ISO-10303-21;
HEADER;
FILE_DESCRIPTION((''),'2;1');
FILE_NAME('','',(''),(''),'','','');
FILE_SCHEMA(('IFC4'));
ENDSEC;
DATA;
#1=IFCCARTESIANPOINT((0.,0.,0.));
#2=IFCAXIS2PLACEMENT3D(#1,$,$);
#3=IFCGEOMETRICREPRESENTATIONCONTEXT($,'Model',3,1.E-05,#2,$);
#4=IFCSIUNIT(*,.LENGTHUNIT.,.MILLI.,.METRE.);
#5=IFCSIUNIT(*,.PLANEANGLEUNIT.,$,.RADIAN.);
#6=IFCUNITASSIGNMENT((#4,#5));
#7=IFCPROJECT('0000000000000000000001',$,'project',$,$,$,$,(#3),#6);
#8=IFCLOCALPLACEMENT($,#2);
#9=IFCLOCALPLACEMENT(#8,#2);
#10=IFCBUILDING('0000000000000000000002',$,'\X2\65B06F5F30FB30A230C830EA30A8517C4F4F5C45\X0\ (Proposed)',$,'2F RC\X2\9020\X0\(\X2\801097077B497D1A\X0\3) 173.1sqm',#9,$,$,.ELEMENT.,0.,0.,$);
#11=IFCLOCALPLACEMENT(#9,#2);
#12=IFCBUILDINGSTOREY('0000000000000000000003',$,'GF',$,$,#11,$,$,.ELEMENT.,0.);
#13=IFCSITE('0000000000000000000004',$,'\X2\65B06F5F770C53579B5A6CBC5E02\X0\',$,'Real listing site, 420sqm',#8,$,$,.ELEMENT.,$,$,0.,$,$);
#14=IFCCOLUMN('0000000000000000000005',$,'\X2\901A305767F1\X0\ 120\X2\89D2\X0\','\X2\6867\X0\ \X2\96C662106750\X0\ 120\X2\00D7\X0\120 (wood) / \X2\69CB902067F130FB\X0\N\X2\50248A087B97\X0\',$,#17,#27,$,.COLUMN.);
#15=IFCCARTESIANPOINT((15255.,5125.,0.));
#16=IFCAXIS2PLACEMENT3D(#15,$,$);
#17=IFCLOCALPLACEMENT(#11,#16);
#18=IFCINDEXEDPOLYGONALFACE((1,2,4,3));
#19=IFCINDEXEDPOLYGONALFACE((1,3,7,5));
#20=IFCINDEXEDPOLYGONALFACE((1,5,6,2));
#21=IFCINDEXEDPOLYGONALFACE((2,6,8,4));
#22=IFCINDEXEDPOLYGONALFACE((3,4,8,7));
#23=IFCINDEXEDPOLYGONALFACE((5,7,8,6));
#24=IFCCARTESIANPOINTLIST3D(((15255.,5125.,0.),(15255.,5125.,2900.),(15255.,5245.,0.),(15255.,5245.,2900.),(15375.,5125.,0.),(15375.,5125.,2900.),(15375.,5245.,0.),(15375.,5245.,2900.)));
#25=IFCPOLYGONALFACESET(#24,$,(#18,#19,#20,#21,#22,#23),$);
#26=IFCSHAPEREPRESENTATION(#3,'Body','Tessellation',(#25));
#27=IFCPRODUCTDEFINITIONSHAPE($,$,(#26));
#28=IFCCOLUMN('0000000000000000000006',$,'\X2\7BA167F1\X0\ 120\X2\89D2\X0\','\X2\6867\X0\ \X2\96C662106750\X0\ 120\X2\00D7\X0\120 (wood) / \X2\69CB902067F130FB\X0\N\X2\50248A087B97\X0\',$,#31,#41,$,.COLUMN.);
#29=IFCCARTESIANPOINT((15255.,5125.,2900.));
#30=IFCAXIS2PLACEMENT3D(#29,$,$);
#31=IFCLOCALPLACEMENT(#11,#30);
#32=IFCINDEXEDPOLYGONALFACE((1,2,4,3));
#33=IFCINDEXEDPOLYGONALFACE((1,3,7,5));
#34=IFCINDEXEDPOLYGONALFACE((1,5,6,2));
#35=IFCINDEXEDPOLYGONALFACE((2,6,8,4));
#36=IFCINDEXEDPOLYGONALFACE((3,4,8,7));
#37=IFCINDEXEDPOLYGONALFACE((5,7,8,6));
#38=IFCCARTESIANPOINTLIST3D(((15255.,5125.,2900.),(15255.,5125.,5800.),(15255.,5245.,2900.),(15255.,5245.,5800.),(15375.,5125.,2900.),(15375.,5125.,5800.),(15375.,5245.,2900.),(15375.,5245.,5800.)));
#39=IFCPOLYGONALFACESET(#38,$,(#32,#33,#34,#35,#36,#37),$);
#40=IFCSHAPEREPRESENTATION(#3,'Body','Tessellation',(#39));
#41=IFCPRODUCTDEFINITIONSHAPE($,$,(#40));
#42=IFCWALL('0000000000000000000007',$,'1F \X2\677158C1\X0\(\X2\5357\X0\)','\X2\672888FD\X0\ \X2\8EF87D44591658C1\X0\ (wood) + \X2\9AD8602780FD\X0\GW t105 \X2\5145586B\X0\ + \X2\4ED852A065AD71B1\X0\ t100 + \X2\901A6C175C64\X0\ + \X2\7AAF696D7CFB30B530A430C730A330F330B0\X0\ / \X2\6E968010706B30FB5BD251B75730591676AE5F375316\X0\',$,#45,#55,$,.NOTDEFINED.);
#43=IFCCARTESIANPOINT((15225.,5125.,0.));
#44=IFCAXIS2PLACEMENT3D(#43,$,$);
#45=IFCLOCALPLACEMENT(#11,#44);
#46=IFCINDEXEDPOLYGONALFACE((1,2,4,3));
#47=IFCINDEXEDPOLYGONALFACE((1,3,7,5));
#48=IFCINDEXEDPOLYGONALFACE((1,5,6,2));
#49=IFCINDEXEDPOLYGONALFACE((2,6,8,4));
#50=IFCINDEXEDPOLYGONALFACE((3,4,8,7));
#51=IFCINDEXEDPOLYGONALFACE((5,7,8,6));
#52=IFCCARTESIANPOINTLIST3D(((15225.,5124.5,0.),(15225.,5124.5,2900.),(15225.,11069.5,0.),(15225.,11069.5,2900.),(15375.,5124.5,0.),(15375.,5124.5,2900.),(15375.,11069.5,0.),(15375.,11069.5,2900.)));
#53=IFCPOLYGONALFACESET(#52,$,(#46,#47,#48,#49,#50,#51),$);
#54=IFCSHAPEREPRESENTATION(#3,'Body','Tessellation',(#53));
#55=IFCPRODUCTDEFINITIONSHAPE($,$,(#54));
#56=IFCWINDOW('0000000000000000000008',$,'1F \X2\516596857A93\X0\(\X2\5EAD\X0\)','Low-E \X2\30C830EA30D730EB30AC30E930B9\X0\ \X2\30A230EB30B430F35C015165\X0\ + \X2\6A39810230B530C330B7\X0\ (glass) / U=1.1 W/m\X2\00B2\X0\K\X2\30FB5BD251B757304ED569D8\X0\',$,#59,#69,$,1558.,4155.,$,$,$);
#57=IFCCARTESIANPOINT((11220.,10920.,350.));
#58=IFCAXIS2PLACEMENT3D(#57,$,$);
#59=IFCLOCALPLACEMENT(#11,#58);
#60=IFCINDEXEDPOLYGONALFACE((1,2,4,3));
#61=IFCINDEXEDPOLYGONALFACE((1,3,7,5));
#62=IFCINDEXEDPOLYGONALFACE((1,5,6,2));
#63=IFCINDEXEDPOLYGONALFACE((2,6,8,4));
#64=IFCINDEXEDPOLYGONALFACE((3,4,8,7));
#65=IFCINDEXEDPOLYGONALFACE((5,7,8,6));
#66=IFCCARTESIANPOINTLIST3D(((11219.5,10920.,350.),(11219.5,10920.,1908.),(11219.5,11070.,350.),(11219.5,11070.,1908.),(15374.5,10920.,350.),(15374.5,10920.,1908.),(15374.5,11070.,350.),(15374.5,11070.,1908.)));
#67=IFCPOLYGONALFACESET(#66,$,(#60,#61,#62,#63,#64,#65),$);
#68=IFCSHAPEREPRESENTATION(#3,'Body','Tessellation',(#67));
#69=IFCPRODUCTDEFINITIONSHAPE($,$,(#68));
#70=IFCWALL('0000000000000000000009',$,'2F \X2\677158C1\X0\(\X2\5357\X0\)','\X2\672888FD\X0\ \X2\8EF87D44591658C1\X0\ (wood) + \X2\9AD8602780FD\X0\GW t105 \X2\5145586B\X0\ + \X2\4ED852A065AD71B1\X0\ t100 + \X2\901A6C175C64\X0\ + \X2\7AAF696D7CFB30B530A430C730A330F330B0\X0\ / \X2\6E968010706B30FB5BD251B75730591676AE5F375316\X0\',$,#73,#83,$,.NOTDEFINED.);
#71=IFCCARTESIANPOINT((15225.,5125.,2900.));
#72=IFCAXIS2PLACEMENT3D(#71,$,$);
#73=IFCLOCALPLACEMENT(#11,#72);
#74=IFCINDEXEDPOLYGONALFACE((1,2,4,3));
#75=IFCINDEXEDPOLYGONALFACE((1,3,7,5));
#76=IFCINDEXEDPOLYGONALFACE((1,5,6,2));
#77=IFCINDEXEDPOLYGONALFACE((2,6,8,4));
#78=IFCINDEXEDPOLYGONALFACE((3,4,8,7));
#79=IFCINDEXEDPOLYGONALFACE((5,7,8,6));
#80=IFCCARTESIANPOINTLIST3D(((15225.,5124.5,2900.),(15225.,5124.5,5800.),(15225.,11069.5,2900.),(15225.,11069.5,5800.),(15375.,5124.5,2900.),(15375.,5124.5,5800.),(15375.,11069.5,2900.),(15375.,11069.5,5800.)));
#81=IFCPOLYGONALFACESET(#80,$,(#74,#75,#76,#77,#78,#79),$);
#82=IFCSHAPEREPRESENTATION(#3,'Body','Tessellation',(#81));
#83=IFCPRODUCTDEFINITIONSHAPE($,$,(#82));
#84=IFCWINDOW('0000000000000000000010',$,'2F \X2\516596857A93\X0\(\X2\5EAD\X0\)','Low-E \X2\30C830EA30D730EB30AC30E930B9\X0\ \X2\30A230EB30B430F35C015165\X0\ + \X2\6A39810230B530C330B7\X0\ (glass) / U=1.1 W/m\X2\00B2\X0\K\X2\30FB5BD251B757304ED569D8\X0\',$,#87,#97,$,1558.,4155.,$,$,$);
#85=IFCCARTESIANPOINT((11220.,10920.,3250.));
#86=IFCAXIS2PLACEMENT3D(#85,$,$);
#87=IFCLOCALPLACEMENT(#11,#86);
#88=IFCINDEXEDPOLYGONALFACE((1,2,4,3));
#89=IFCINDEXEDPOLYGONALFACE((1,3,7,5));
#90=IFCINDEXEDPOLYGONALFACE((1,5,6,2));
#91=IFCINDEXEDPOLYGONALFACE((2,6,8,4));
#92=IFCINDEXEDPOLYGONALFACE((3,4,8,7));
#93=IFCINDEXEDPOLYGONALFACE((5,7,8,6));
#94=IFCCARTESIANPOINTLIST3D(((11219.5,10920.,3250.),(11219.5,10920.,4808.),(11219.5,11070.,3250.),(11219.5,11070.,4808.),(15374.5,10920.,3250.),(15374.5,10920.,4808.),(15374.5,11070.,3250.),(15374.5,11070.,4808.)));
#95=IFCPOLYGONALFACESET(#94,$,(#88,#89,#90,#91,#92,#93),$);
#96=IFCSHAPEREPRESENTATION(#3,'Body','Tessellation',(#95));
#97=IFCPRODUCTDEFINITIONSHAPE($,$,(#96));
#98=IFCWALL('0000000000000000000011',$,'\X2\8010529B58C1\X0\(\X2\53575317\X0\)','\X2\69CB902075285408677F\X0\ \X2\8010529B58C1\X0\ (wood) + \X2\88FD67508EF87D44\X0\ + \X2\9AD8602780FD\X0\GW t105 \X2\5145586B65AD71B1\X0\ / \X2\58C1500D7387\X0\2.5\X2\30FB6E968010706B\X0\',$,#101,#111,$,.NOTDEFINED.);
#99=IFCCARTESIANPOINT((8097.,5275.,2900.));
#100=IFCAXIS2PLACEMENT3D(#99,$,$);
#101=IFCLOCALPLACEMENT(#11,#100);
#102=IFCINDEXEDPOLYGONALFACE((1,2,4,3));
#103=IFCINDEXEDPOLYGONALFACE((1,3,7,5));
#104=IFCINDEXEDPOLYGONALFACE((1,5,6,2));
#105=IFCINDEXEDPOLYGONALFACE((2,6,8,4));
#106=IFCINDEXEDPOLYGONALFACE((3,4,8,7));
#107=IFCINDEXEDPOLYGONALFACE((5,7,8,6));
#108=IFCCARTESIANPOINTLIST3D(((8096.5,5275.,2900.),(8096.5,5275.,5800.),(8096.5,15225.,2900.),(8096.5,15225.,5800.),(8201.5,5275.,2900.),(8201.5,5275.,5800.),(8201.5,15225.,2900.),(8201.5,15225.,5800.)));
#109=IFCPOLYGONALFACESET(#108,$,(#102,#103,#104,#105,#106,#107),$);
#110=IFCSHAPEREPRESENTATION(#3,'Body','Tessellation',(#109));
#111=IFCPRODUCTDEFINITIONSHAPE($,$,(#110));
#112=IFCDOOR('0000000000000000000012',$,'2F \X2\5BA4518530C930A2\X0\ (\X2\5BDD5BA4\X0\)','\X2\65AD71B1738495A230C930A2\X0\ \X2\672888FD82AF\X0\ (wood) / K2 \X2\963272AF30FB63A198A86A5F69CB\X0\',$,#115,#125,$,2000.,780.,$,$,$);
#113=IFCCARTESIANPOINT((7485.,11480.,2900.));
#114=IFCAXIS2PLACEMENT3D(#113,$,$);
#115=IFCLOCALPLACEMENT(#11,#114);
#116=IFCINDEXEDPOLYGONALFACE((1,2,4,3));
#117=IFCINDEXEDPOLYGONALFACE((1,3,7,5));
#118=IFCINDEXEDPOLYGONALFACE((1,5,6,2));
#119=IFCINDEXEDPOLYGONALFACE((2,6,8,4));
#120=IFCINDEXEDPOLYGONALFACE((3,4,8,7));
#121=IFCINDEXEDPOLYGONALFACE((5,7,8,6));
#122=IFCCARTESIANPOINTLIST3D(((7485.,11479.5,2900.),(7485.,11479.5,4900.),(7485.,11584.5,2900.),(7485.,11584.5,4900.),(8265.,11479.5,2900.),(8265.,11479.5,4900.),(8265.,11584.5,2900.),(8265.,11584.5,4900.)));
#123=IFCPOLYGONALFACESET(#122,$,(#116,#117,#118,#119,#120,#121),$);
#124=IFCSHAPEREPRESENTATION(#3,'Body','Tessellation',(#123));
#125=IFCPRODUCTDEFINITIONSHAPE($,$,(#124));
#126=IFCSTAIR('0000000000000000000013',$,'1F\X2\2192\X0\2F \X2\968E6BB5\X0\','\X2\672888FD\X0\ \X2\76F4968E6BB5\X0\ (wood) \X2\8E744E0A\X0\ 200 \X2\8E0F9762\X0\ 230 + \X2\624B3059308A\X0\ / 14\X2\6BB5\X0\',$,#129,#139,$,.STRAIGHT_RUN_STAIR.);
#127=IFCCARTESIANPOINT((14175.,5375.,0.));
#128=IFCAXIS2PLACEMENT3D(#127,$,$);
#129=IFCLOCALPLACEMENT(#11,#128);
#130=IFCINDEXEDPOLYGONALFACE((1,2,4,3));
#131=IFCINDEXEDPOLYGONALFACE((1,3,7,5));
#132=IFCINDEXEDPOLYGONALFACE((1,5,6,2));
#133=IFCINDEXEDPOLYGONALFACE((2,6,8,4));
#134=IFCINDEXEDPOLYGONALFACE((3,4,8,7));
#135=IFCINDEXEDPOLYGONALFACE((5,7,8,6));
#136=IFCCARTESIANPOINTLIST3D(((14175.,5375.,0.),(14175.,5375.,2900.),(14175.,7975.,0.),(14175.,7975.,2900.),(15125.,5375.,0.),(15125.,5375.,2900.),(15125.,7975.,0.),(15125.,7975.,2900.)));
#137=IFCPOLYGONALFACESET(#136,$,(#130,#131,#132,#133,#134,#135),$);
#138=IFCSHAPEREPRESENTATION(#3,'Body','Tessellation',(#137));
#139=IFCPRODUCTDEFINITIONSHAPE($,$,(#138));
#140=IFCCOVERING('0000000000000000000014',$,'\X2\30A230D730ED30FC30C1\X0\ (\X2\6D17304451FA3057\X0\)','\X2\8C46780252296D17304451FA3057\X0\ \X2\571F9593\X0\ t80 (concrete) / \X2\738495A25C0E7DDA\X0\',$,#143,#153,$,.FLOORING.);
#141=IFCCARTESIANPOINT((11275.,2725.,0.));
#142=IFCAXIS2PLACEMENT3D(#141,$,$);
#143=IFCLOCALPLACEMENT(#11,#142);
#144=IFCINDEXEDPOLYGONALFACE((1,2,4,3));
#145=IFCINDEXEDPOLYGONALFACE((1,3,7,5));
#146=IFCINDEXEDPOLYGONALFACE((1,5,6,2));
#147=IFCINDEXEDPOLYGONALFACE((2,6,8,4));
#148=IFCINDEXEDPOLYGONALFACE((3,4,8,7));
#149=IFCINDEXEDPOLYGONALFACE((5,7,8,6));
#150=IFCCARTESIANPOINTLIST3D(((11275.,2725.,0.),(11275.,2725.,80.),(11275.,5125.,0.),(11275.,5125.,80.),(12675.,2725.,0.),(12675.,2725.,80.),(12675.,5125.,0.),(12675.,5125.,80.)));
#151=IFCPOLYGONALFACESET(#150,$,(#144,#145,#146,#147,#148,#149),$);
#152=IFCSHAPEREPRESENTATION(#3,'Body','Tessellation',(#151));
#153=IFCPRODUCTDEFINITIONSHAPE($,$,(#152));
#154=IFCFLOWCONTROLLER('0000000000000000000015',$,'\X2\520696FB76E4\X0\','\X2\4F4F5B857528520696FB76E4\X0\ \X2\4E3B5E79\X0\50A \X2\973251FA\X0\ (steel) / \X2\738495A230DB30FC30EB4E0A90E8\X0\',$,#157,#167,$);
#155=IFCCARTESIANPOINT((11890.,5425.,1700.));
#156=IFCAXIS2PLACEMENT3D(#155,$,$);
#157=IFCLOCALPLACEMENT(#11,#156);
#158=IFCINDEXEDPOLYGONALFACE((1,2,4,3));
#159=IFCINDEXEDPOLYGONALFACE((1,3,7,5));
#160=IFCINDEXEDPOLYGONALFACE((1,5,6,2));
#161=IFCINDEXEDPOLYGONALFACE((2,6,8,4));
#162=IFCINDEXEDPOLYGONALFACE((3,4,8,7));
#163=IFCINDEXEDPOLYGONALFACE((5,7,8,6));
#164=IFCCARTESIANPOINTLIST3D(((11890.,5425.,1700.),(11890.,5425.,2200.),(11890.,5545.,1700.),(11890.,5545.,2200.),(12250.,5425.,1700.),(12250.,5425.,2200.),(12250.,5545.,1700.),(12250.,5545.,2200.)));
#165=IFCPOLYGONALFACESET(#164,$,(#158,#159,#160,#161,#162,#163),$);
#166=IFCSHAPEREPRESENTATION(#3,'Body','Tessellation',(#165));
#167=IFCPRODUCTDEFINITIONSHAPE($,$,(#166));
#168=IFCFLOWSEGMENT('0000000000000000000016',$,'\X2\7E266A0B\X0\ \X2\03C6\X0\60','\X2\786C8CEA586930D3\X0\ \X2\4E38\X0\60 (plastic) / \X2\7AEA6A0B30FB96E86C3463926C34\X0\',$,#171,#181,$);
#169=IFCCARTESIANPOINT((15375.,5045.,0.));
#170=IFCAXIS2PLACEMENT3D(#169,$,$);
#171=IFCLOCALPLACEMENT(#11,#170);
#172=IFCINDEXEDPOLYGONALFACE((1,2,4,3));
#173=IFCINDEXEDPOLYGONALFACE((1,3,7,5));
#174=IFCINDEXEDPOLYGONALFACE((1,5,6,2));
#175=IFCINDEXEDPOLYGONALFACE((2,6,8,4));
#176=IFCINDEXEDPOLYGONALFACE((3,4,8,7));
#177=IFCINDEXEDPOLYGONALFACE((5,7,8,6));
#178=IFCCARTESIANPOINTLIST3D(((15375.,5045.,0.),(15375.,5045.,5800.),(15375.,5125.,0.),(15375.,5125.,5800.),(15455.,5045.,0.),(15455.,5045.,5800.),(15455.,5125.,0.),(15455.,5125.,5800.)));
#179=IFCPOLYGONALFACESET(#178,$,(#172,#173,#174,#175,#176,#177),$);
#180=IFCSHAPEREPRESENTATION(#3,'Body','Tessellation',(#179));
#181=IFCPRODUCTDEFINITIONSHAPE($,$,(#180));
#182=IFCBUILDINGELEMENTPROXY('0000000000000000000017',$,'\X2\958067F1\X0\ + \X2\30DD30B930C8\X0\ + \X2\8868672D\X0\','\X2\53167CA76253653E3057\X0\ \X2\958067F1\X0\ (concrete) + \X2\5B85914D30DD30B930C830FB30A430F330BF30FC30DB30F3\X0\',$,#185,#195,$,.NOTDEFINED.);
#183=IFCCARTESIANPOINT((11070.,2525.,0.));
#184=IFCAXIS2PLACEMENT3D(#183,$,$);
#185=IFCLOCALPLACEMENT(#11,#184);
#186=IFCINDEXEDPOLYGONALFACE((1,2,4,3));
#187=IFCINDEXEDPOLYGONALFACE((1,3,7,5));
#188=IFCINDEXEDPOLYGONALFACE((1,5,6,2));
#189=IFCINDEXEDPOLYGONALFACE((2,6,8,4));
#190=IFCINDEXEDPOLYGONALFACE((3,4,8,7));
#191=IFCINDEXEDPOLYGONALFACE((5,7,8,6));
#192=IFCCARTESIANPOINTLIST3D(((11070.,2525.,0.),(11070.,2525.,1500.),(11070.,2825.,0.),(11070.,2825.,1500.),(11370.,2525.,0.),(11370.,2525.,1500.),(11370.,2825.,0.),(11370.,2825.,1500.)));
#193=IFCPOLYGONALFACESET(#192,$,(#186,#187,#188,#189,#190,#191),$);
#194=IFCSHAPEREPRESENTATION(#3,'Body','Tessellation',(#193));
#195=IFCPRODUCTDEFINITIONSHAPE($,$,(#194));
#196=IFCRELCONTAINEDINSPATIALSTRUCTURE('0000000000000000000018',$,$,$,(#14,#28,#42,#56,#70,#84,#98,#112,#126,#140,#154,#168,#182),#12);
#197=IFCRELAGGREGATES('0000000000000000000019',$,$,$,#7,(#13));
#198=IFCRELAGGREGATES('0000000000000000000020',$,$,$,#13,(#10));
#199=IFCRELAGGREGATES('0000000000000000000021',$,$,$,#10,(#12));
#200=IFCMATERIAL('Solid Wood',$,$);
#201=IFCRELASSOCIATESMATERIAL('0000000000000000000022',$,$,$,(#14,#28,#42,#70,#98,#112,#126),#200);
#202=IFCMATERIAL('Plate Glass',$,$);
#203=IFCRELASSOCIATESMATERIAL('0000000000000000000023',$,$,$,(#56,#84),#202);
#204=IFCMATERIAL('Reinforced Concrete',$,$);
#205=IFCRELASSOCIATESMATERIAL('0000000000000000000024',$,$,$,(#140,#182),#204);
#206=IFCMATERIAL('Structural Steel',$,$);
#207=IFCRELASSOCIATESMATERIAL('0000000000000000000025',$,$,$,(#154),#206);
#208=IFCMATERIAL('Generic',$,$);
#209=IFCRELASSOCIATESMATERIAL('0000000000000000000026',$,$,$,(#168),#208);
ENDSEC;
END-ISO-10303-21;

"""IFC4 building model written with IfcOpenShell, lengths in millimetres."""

from ifc_helpers import new_model, si_unit, frame, frame_2d, origin, place, context, project, spatial, rectangle, extrude, material, element, fill, save


model = new_model("IFC4")

# Units and contexts
model_context = context("Model", 3, precision=1e-05, world=origin())
ifc_project = project(units=[si_unit("LENGTHUNIT", "METRE", prefix="MILLI"), si_unit("PLANEANGLEUNIT", "RADIAN")], contexts=[model_context])

# Site, building, storey
site_placement = place(None, origin())
site = spatial("IfcSite", under=ifc_project, at=site_placement, Name="新潟県南魚沼市", ObjectType="Real listing site, 420sqm", CompositionType="ELEMENT", RefElevation=0.0)
building_placement = place(site_placement, origin())
building = spatial("IfcBuilding", under=site, at=building_placement, Name="新潟・アトリエ兼住居 (Proposed)", ObjectType="2F RC造(耐震等級3) 173.1sqm", CompositionType="ELEMENT", ElevationOfRefHeight=0.0, ElevationOfTerrain=0.0)
storey_placement = place(building_placement, origin())
storey = spatial("IfcBuildingStorey", under=building, at=storey_placement, Name="GF", CompositionType="ELEMENT", Elevation=0.0)

# Columns
ifc_material_1 = material(Name="Solid Wood")
column_1_placement = place(storey_placement, frame((15255.0, 5125.0, 0.0)))
element("IfcColumn", 1, at=column_1_placement, inside=storey, material=ifc_material_1, Name="通し柱 120角", Description="桧 集成材 120×120 (wood) / 構造柱・N値計算", PredefinedType="COLUMN", context=model_context, shape_type="SweptSolid", body=[
    extrude(rectangle(XDim=120.0, YDim=120.0, at=frame_2d((60.0, 60.0))), frame((15255.0, 5125.0, 0.0)), (0.0, 0.0, 1.0), 2900.0),
])
column_2_placement = place(storey_placement, frame((15255.0, 5125.0, 2900.0)))
element("IfcColumn", 2, at=column_2_placement, inside=storey, material=ifc_material_1, Name="管柱 120角", Description="桧 集成材 120×120 (wood) / 構造柱・N値計算", PredefinedType="COLUMN", context=model_context, shape_type="SweptSolid", body=[
    extrude(rectangle(XDim=120.0, YDim=120.0, at=frame_2d((60.0, 60.0))), frame((15255.0, 5125.0, 2900.0)), (0.0, 0.0, 1.0), 2900.0),
])

# Wall, opening, window
wall_1_placement = place(storey_placement, frame((15225.0, 5125.0, 0.0)))
wall_1 = element("IfcWall", 3, at=wall_1_placement, inside=storey, material=ifc_material_1, Name="1F 東壁(南)", Description="木製 軸組外壁 (wood) + 高性能GW t105 充填 + 付加断熱 t100 + 通気層 + 窯業系サイディング / 準耐火・寒冷地外皮強化", PredefinedType="NOTDEFINED", context=model_context, shape_type="SweptSolid", body=[
    extrude(rectangle(XDim=150.0, YDim=5945.0, at=frame_2d((75.0, 2972.0))), frame((15225.0, 5125.0, 0.0)), (0.0, 0.0, 1.0), 2900.0),
])
opening_1_placement = place(storey_placement, frame((11220.0, 10920.0, 350.0)))
opening_1 = element("IfcOpeningElement", 4, at=opening_1_placement, cuts=wall_1, PredefinedType="NOTDEFINED", context=model_context, shape_type="SweptSolid", body=[
    extrude(rectangle(XDim=4155.0, YDim=150.0, at=frame_2d((2077.0, 75.0))), frame((11220.0, 10920.0, 350.0)), (0.0, 0.0, 1.0), 1558.0),
])
ifc_material_2 = material(Name="Plate Glass")
window_1_placement = place(storey_placement, frame((11220.0, 10920.0, 350.0)))
window_1 = element("IfcWindow", 5, at=window_1_placement, inside=storey, material=ifc_material_2, Name="1F 入隅窓(庭)", Description="Low-E トリプルガラス アルゴン封入 + 樹脂サッシ (glass) / U=1.1 W/m²K・寒冷地仕様", OverallHeight=1558.0, OverallWidth=4155.0, context=model_context, shape_type="SweptSolid", body=[
    extrude(rectangle(XDim=4155.0, YDim=150.0, at=frame_2d((2077.0, 75.0))), frame((11220.0, 10920.0, 350.0)), (0.0, 0.0, 1.0), 1558.0),
])
fill(opening_1, window_1)

# Wall, opening, window
wall_2_placement = place(storey_placement, frame((15225.0, 5125.0, 2900.0)))
wall_2 = element("IfcWall", 6, at=wall_2_placement, inside=storey, material=ifc_material_1, Name="2F 東壁(南)", Description="木製 軸組外壁 (wood) + 高性能GW t105 充填 + 付加断熱 t100 + 通気層 + 窯業系サイディング / 準耐火・寒冷地外皮強化", PredefinedType="NOTDEFINED", context=model_context, shape_type="SweptSolid", body=[
    extrude(rectangle(XDim=150.0, YDim=5945.0, at=frame_2d((75.0, 2972.0))), frame((15225.0, 5125.0, 2900.0)), (0.0, 0.0, 1.0), 2900.0),
])
opening_2_placement = place(storey_placement, frame((11220.0, 10920.0, 3250.0)))
opening_2 = element("IfcOpeningElement", 7, at=opening_2_placement, cuts=wall_2, PredefinedType="NOTDEFINED", context=model_context, shape_type="SweptSolid", body=[
    extrude(rectangle(XDim=4155.0, YDim=150.0, at=frame_2d((2077.0, 75.0))), frame((11220.0, 10920.0, 3250.0)), (0.0, 0.0, 1.0), 1558.0),
])
window_2_placement = place(storey_placement, frame((11220.0, 10920.0, 3250.0)))
window_2 = element("IfcWindow", 8, at=window_2_placement, inside=storey, material=ifc_material_2, Name="2F 入隅窓(庭)", Description="Low-E トリプルガラス アルゴン封入 + 樹脂サッシ (glass) / U=1.1 W/m²K・寒冷地仕様", OverallHeight=1558.0, OverallWidth=4155.0, context=model_context, shape_type="SweptSolid", body=[
    extrude(rectangle(XDim=4155.0, YDim=150.0, at=frame_2d((2077.0, 75.0))), frame((11220.0, 10920.0, 3250.0)), (0.0, 0.0, 1.0), 1558.0),
])
fill(opening_2, window_2)

# Wall, opening, door
wall_3_placement = place(storey_placement, frame((8097.0, 5275.0, 2900.0)))
wall_3 = element("IfcWall", 9, at=wall_3_placement, inside=storey, material=ifc_material_1, Name="耐力壁(南北)", Description="構造用合板 耐力壁 (wood) + 製材軸組 + 高性能GW t105 充填断熱 / 壁倍率2.5・準耐火", PredefinedType="NOTDEFINED", context=model_context, shape_type="SweptSolid", body=[
    extrude(rectangle(XDim=105.0, YDim=9950.0, at=frame_2d((52.0, 4975.0))), frame((8097.0, 5275.0, 2900.0)), (0.0, 0.0, 1.0), 2900.0),
])
opening_3_placement = place(storey_placement, frame((7485.0, 11480.0, 2900.0)))
opening_3 = element("IfcOpeningElement", 10, at=opening_3_placement, cuts=wall_3, PredefinedType="NOTDEFINED", context=model_context, shape_type="SweptSolid", body=[
    extrude(rectangle(XDim=780.0, YDim=105.0, at=frame_2d((390.0, 52.0))), frame((7485.0, 11480.0, 2900.0)), (0.0, 0.0, 1.0), 2000.0),
])
door_1_placement = place(storey_placement, frame((7485.0, 11480.0, 2900.0)))
door_1 = element("IfcDoor", 11, at=door_1_placement, inside=storey, material=ifc_material_1, Name="2F 室内ドア (寝室)", Description="断熱玄関ドア 木製芯 (wood) / K2 防犯・採風機構", OverallHeight=2000.0, OverallWidth=780.0, context=model_context, shape_type="SweptSolid", body=[
    extrude(rectangle(XDim=780.0, YDim=105.0, at=frame_2d((390.0, 52.0))), frame((7485.0, 11480.0, 2900.0)), (0.0, 0.0, 1.0), 2000.0),
])
fill(opening_3, door_1)

# Stair
stair_placement = place(storey_placement, frame((14175.0, 5375.0, 0.0)))
element("IfcStair", 12, at=stair_placement, inside=storey, material=ifc_material_1, Name="1F→2F 階段", Description="木製 直階段 (wood) 蹴上 200 踏面 230 + 手すり / 14段", PredefinedType="STRAIGHT_RUN_STAIR", context=model_context, shape_type="SweptSolid", body=[
    extrude(rectangle(XDim=950.0, YDim=2600.0, at=frame_2d((475.0, 1300.0))), frame((14175.0, 5375.0, 0.0)), (0.0, 0.0, 1.0), 2900.0),
])

# Covering
ifc_material_3 = material(Name="Reinforced Concrete")
covering_placement = place(storey_placement, frame((11275.0, 2725.0, 0.0)))
element("IfcCovering", 13, at=covering_placement, inside=storey, material=ifc_material_3, Name="アプローチ (洗い出し)", Description="豆砂利洗い出し 土間 t80 (concrete) / 玄関導線", PredefinedType="FLOORING", context=model_context, shape_type="SweptSolid", body=[
    extrude(rectangle(XDim=1400.0, YDim=2400.0, at=frame_2d((700.0, 1200.0))), frame((11275.0, 2725.0, 0.0)), (0.0, 0.0, 1.0), 80.0),
])

# Flow controller
ifc_material_4 = material(Name="Structural Steel")
flow_controller_placement = place(storey_placement, frame((11890.0, 5425.0, 1700.0)))
element("IfcFlowController", 14, at=flow_controller_placement, inside=storey, material=ifc_material_4, Name="分電盤", Description="住宅用分電盤 主幹50A 露出 (steel) / 玄関ホール上部", context=model_context, shape_type="SweptSolid", body=[
    extrude(rectangle(XDim=360.0, YDim=120.0, at=frame_2d((180.0, 60.0))), frame((11890.0, 5425.0, 1700.0)), (0.0, 0.0, 1.0), 500.0),
])

# Flow segment
ifc_material_5 = material(Name="Generic")
flow_segment_placement = place(storey_placement, frame((15375.0, 5045.0, 0.0)))
element("IfcFlowSegment", 15, at=flow_segment_placement, inside=storey, material=ifc_material_5, Name="縦樋 φ60", Description="硬質塩ビ 丸60 (plastic) / 竪樋・雨水排水", context=model_context, shape_type="SweptSolid", body=[
    extrude(rectangle(XDim=80.0, YDim=80.0, at=frame_2d((40.0, 40.0))), frame((15375.0, 5045.0, 0.0)), (0.0, 0.0, 1.0), 5800.0),
])

# Building element proxy
proxy_placement = place(storey_placement, frame((11070.0, 2525.0, 0.0)))
element("IfcBuildingElementProxy", 16, at=proxy_placement, inside=storey, material=ifc_material_3, Name="門柱 + ポスト + 表札", Description="化粧打放し 門柱 (concrete) + 宅配ポスト・インターホン", PredefinedType="NOTDEFINED", context=model_context, shape_type="SweptSolid", body=[
    extrude(rectangle(XDim=300.0, YDim=300.0, at=frame_2d((150.0, 150.0))), frame((11070.0, 2525.0, 0.0)), (0.0, 0.0, 1.0), 1500.0),
])

save(model, "model.ifc")
